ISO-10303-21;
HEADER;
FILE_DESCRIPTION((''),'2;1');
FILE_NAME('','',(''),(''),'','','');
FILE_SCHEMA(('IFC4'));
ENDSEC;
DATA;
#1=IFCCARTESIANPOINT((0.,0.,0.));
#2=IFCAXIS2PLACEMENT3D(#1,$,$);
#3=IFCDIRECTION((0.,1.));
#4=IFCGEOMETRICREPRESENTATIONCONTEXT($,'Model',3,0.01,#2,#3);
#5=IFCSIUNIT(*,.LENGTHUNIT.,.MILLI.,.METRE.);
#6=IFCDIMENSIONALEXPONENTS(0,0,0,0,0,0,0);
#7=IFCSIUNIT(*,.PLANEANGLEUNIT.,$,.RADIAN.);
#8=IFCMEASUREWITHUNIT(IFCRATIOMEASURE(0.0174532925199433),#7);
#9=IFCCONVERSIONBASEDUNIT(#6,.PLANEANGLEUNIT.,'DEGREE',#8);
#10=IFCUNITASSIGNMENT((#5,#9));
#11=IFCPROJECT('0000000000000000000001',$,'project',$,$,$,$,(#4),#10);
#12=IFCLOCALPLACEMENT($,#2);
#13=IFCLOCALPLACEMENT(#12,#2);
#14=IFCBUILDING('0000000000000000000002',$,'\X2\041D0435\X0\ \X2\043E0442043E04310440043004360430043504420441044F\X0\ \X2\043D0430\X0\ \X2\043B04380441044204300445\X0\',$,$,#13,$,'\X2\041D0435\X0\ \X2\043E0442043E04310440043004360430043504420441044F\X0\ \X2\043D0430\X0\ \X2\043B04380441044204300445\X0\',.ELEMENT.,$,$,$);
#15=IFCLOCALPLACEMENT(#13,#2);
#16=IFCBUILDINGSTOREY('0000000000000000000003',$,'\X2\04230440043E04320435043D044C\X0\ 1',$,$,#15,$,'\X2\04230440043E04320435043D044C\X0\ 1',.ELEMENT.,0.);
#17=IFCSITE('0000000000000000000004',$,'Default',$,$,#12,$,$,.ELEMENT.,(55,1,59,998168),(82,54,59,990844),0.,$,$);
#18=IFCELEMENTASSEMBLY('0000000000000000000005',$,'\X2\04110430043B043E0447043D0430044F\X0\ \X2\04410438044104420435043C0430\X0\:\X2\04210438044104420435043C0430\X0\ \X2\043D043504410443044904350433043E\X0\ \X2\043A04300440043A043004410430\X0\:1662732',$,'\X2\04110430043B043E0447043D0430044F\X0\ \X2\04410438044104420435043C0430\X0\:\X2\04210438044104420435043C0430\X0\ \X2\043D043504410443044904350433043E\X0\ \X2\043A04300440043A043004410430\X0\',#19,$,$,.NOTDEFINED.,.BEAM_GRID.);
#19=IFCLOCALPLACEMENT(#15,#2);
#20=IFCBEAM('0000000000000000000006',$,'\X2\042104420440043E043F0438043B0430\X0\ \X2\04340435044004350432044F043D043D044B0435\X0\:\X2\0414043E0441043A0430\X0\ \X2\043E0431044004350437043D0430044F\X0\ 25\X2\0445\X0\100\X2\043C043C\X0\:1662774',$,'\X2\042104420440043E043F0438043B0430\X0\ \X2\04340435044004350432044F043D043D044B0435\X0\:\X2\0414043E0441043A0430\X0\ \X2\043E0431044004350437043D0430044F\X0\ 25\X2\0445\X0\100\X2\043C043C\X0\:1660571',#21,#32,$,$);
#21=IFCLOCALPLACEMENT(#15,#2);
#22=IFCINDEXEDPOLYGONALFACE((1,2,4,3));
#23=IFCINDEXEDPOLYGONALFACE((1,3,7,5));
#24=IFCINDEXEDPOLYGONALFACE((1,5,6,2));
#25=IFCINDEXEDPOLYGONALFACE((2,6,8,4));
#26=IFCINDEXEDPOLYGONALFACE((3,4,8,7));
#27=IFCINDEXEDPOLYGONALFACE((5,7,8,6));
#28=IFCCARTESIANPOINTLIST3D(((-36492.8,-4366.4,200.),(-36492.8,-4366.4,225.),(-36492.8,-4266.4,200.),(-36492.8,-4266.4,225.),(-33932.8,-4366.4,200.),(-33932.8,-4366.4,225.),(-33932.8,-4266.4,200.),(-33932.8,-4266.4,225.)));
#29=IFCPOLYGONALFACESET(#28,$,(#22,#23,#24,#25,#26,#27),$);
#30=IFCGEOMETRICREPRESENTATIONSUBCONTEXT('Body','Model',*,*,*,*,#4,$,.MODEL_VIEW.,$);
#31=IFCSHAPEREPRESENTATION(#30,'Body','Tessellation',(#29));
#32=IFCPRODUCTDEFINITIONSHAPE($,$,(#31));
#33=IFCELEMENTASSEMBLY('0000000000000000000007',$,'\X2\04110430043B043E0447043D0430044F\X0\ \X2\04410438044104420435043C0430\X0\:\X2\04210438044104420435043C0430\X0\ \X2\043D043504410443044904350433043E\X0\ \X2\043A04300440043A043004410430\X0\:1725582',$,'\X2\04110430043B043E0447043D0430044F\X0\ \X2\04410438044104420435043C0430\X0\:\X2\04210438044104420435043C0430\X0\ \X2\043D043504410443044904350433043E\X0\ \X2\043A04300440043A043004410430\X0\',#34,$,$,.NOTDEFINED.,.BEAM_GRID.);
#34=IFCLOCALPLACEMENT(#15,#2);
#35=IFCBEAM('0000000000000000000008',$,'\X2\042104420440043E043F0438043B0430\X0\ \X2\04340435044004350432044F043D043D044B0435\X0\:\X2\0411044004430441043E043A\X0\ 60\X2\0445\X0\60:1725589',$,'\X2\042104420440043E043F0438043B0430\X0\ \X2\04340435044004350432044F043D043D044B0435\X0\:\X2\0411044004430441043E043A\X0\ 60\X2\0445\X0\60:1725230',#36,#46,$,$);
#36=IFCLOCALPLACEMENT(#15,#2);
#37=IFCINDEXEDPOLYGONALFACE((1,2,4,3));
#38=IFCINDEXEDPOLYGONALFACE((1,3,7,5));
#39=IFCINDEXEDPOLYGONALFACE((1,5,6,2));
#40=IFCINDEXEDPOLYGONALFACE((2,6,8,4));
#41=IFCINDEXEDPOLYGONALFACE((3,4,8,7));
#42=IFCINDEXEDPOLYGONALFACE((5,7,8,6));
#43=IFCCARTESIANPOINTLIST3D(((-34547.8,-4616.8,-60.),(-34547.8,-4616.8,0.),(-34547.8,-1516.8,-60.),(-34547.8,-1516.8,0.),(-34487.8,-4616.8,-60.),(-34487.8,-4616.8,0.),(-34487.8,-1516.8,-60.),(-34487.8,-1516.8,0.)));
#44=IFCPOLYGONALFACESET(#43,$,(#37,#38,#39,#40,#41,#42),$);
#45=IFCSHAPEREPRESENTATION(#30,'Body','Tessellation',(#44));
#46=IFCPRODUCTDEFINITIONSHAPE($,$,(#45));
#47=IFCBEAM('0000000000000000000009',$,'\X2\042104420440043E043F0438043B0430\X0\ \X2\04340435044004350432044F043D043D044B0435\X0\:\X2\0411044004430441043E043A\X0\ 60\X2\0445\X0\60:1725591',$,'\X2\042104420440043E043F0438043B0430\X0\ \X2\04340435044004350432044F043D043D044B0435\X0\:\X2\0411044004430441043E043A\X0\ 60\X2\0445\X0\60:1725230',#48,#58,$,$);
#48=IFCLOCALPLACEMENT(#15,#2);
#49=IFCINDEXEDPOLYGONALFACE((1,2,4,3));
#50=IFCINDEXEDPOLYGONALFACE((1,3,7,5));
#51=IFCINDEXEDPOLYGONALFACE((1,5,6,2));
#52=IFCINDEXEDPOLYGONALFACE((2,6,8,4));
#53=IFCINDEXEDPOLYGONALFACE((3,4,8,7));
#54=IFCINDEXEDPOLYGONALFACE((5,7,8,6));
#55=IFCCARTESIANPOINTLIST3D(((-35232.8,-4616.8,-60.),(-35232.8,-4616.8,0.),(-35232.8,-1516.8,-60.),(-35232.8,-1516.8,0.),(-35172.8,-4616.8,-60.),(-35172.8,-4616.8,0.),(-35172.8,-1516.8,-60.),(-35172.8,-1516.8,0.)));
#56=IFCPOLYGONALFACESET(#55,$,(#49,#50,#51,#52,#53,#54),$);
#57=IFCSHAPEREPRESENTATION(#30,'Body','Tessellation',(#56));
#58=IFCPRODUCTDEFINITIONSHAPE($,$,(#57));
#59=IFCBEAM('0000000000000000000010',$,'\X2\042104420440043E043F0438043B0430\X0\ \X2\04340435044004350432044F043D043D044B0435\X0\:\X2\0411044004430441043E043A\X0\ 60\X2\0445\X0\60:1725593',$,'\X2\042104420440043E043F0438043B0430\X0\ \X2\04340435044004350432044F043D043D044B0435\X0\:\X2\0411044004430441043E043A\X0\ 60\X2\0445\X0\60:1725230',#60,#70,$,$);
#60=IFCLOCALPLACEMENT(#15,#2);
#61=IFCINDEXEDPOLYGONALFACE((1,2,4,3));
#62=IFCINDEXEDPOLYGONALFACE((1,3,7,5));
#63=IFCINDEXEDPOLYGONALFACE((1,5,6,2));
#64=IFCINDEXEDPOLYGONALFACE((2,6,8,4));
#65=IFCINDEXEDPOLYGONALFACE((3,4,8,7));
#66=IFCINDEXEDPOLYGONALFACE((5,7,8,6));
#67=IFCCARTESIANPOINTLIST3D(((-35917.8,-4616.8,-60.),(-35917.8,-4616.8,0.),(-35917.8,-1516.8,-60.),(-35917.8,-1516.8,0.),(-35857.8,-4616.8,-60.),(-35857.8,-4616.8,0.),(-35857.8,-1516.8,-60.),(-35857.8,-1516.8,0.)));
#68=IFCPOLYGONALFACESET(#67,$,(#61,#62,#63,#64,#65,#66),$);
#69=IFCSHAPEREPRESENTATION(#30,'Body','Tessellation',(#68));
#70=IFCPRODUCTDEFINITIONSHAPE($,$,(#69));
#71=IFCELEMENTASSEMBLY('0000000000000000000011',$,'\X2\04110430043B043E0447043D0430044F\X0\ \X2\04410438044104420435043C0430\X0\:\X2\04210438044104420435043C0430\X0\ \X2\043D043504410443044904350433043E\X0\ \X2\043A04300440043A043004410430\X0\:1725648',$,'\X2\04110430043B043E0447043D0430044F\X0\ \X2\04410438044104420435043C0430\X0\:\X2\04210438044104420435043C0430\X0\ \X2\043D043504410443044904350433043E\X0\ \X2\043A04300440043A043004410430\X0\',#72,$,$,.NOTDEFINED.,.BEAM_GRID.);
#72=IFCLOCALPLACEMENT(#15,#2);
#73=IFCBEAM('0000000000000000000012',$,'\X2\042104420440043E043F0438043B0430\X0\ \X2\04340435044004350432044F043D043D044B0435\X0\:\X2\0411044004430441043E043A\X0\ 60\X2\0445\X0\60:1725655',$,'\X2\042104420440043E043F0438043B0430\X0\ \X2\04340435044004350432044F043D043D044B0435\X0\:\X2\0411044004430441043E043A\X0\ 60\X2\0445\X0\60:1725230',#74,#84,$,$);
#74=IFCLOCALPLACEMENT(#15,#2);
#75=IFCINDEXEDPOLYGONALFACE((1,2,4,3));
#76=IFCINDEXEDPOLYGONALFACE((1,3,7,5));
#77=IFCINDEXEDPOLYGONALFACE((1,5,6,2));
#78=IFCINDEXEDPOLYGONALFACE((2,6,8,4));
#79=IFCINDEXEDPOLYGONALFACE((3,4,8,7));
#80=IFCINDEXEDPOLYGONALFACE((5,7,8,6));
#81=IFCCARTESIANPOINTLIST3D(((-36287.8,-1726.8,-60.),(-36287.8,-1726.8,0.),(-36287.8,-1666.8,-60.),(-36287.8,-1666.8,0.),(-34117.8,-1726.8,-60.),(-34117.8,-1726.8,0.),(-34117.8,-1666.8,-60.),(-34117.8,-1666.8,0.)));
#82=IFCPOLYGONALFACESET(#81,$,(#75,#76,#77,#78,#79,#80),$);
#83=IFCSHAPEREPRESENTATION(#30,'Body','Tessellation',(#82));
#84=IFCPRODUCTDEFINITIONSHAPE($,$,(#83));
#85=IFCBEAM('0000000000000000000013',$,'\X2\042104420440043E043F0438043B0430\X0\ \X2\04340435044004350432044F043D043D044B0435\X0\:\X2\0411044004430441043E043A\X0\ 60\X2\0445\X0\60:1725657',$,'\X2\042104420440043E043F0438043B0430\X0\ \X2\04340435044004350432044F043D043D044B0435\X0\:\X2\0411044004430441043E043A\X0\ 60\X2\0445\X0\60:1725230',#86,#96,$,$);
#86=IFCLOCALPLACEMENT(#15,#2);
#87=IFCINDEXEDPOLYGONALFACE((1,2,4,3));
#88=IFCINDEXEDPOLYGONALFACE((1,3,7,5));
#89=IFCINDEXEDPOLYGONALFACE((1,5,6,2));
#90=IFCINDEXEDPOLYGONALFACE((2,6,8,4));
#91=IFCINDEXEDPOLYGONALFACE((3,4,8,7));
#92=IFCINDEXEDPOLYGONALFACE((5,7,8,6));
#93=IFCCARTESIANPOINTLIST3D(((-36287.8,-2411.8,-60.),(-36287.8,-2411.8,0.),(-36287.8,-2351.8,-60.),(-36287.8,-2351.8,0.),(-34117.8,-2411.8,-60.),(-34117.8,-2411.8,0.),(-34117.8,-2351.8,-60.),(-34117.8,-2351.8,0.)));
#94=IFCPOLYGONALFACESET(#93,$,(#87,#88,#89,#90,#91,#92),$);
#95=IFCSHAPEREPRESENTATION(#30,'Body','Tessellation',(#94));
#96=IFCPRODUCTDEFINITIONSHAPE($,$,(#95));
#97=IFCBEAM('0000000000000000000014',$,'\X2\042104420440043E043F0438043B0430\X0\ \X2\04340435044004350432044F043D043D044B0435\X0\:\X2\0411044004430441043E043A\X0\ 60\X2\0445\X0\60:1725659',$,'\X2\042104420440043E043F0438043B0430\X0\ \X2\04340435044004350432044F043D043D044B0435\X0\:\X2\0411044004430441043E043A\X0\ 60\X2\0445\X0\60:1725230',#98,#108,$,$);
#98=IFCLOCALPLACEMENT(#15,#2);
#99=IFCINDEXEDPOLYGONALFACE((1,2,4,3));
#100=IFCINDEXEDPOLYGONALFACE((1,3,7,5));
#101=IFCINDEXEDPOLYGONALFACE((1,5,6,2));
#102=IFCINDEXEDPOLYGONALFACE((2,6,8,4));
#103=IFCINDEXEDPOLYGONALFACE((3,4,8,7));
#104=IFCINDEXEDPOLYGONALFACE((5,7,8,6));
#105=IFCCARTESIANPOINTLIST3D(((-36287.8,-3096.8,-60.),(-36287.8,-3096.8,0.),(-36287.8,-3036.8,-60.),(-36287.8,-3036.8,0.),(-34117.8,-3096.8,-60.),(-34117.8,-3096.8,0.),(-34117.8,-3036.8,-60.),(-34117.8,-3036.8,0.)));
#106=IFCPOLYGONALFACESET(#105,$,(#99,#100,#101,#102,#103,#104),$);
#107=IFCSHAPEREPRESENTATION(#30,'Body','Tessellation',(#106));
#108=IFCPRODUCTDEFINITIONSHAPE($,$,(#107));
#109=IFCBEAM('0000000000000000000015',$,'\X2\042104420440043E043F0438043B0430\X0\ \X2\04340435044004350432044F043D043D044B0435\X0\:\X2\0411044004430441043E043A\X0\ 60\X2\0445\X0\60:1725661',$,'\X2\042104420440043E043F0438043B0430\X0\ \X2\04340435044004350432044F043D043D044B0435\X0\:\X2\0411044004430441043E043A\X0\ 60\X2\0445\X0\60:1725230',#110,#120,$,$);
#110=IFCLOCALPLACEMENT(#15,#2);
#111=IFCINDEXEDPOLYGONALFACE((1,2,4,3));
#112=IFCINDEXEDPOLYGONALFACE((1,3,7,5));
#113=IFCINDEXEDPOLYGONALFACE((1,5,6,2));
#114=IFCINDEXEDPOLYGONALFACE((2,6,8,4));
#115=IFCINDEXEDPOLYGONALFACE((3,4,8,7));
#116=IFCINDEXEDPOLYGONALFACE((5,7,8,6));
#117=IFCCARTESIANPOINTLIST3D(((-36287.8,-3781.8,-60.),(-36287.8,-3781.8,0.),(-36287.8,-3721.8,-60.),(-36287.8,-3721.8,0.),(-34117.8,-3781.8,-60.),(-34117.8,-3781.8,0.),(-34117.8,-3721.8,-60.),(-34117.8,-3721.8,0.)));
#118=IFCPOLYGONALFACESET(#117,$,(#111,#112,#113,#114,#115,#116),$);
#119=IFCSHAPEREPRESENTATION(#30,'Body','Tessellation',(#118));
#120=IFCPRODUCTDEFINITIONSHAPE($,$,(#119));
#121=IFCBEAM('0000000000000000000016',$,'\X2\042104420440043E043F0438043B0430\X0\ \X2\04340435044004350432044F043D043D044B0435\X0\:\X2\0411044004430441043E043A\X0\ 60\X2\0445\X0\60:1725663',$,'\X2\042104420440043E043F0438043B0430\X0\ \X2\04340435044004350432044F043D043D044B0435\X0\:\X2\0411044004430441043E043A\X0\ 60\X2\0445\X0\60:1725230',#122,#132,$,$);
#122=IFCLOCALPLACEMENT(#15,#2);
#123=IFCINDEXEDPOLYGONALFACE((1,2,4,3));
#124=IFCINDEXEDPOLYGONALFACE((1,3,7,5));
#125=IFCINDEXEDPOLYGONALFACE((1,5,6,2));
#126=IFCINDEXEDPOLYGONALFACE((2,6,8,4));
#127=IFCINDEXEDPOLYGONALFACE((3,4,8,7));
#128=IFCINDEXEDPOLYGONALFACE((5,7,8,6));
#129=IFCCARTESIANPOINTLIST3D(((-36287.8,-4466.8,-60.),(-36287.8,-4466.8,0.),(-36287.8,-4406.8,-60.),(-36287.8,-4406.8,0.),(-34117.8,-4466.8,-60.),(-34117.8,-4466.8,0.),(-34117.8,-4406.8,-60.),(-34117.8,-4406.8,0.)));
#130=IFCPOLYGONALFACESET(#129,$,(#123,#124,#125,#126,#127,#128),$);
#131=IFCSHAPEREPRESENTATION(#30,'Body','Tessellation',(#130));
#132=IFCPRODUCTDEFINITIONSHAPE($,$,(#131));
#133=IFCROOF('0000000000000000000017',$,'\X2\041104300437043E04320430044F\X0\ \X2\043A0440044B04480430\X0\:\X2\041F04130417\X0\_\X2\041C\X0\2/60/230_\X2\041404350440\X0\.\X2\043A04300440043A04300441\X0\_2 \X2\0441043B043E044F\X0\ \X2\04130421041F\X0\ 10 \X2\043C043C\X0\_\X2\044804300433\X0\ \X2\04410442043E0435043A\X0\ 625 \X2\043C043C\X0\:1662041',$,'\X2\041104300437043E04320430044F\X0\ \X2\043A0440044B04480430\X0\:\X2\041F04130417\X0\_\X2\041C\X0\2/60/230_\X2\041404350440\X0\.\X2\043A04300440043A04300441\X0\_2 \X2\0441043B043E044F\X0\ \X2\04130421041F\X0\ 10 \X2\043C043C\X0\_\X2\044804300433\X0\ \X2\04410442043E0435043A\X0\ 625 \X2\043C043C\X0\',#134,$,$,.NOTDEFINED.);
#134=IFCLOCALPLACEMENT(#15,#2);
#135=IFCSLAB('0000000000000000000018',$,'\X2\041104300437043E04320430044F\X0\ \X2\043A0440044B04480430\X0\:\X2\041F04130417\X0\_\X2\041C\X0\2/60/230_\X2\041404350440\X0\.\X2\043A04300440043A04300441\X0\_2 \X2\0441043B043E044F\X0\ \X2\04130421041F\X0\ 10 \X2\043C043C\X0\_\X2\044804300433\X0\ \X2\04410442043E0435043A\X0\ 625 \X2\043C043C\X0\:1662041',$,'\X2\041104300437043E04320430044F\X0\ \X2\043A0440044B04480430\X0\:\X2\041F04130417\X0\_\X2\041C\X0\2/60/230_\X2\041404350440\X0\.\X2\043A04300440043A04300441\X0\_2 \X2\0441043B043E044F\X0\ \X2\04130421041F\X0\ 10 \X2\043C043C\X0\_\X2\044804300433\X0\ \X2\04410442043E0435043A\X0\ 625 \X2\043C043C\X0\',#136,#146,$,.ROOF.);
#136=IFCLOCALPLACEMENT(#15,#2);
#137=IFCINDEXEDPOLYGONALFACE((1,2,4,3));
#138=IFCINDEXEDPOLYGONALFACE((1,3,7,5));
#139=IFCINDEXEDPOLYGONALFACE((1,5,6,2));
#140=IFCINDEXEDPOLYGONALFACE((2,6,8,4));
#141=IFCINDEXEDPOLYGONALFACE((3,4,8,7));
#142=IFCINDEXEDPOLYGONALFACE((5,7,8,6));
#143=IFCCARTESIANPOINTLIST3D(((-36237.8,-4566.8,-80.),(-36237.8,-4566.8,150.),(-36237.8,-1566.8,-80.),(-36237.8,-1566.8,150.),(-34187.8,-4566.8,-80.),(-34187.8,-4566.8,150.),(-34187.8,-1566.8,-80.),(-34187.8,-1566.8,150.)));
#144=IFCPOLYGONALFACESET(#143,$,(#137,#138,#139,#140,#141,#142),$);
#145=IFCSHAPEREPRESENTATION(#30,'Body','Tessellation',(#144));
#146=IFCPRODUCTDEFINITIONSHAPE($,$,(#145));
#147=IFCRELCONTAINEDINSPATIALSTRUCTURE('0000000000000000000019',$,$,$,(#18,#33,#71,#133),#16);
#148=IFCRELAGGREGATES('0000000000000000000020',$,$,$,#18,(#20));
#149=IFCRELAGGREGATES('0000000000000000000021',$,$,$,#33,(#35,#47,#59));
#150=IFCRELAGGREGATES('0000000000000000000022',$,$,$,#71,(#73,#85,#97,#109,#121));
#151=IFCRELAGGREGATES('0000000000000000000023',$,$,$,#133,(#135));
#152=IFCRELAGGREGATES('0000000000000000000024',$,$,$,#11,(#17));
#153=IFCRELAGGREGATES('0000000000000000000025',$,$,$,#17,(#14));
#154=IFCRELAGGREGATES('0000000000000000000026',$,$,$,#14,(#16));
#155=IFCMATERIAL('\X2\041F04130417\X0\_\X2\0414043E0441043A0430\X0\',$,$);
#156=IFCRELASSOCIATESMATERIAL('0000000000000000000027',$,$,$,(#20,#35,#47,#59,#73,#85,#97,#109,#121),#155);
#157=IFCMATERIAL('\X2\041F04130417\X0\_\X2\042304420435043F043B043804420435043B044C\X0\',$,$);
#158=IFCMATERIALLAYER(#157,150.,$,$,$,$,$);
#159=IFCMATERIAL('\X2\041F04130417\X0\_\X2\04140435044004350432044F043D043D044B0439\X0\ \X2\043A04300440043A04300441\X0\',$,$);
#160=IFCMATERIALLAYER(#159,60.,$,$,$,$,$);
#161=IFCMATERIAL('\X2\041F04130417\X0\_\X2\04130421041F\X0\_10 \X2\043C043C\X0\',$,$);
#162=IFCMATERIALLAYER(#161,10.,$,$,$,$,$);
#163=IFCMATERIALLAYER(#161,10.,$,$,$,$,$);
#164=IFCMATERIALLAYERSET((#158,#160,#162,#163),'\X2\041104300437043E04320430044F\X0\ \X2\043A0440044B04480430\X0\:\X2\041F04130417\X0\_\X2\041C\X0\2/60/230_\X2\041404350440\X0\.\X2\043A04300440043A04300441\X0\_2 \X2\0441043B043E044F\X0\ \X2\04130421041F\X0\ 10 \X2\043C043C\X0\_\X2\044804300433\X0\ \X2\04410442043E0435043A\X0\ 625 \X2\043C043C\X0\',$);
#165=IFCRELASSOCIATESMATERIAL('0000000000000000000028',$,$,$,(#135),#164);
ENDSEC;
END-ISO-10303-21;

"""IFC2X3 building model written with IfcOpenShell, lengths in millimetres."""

from ifc_helpers import new_model, entity, si_unit, converted_unit, direction, frame, frame_2d, origin, origin_2d_with_axis, place, context, subcontext, project, spatial, rectangle, extrude, material, layer, layer_set, element, aggregate, save


model = new_model("IFC2X3")

# Units and contexts
model_context = context("Model", 3, precision=0.01, world=origin(), true_north=direction((0.0, 1.0)))
body_context = subcontext(model_context, "Body", "Model", "MODEL_VIEW")
ifc_project = project(units=[si_unit("LENGTHUNIT", "METRE", prefix="MILLI"), converted_unit("PLANEANGLEUNIT", "DEGREE", entity("IfcRatioMeasure", 0.0174532925199433), si_unit("PLANEANGLEUNIT", "RADIAN"), dimensions=[0, 0, 0, 0, 0, 0, 0])], contexts=[model_context])

# Site, building, storey
site_placement = place(None, origin())
site = spatial("IfcSite", under=ifc_project, at=site_placement, Name="Default", CompositionType="ELEMENT", RefLatitude=(55, 1, 59, 998168), RefLongitude=(82, 54, 59, 990844), RefElevation=0.0)
building_placement = place(site_placement, origin())
building = spatial("IfcBuilding", under=site, at=building_placement, Name="Не отображается на листах", LongName="Не отображается на листах", CompositionType="ELEMENT")
storey_placement = place(building_placement, frame((0.0, 0.0, 0.0)))
storey = spatial("IfcBuildingStorey", under=building, at=storey_placement, Name="Уровень 1", LongName="Уровень 1", CompositionType="ELEMENT", Elevation=0.0)

# Element assemblies, beams
ifc_material_1 = material(Name="ПГЗ_Доска")
assembly_1_placement = place(storey_placement, origin())
assembly_1 = element("IfcElementAssembly", 1, at=assembly_1_placement, inside=storey, Name="Балочная система:Система несущего каркаса:1662732", ObjectType="Балочная система:Система несущего каркаса", AssemblyPlace="NOTDEFINED", PredefinedType="BEAM_GRID")
beam_1_placement = place(assembly_1_placement, frame((-36492.8, -4316.4, 0.0)))
beam_1 = element("IfcBeam", 2, at=beam_1_placement, material=ifc_material_1, Name="Стропила деревянные:Доска обрезная 25х100мм:1662774", ObjectType="Стропила деревянные:Доска обрезная 25х100мм:1660571", context=body_context, shape_type="SweptSolid", body=[
    extrude(rectangle(XDim=25.0, YDim=100.0, at=origin_2d_with_axis()), frame((0.0, 0.0, 212.5), z_axis=(1.0, 0.0, 0.0), x_axis=(0.0, 0.0, -1.0)), (0.0, 0.0, 1.0), 2560.0),
])
aggregate(assembly_1, [beam_1])
assembly_2_placement = place(storey_placement, origin())
assembly_2 = element("IfcElementAssembly", 3, at=assembly_2_placement, inside=storey, Name="Балочная система:Система несущего каркаса:1725582", ObjectType="Балочная система:Система несущего каркаса", AssemblyPlace="NOTDEFINED", PredefinedType="BEAM_GRID")
beam_2_placement = place(assembly_2_placement, frame((-34517.8, -1516.8, 0.0), z_axis=(0.0, 0.0, 1.0), x_axis=(0.0, -1.0, 0.0)))
beam_2 = element("IfcBeam", 4, at=beam_2_placement, material=ifc_material_1, Name="Стропила деревянные:Брусок 60х60:1725589", ObjectType="Стропила деревянные:Брусок 60х60:1725230", context=body_context, shape_type="SweptSolid", body=[
    extrude(rectangle(XDim=60.0, YDim=60.0, at=frame_2d((0.0, 0.0), x_axis=(1.0, 0.0))), frame((0.0, 0.0, -30.0), z_axis=(1.0, 0.0, 0.0), x_axis=(0.0, 0.0, -1.0)), (0.0, 0.0, 1.0), 3100.0),
])
beam_3_placement = place(assembly_2_placement, frame((-35202.8, -1516.8, 0.0), z_axis=(0.0, 0.0, 1.0), x_axis=(0.0, -1.0, 0.0)))
beam_3 = element("IfcBeam", 5, at=beam_3_placement, material=ifc_material_1, Name="Стропила деревянные:Брусок 60х60:1725591", ObjectType="Стропила деревянные:Брусок 60х60:1725230", context=body_context, shape_type="SweptSolid", body=[
    extrude(rectangle(XDim=60.0, YDim=60.0, at=frame_2d((0.0, 0.0), x_axis=(1.0, 0.0))), frame((0.0, 0.0, -30.0), z_axis=(1.0, 0.0, 0.0), x_axis=(0.0, 0.0, -1.0)), (0.0, 0.0, 1.0), 3100.0),
])
beam_4_placement = place(assembly_2_placement, frame((-35887.8, -1516.8, 0.0), z_axis=(0.0, 0.0, 1.0), x_axis=(0.0, -1.0, 0.0)))
beam_4 = element("IfcBeam", 6, at=beam_4_placement, material=ifc_material_1, Name="Стропила деревянные:Брусок 60х60:1725593", ObjectType="Стропила деревянные:Брусок 60х60:1725230", context=body_context, shape_type="SweptSolid", body=[
    extrude(rectangle(XDim=60.0, YDim=60.0, at=frame_2d((0.0, 0.0), x_axis=(1.0, 0.0))), frame((0.0, 0.0, -30.0), z_axis=(1.0, 0.0, 0.0), x_axis=(0.0, 0.0, -1.0)), (0.0, 0.0, 1.0), 3100.0),
])
aggregate(assembly_2, [beam_2, beam_3, beam_4])
assembly_3_placement = place(storey_placement, origin())
assembly_3 = element("IfcElementAssembly", 7, at=assembly_3_placement, inside=storey, Name="Балочная система:Система несущего каркаса:1725648", ObjectType="Балочная система:Система несущего каркаса", AssemblyPlace="NOTDEFINED", PredefinedType="BEAM_GRID")
beam_5_placement = place(assembly_3_placement, frame((-36287.8, -1696.8, 0.0)))
beam_5 = element("IfcBeam", 8, at=beam_5_placement, material=ifc_material_1, Name="Стропила деревянные:Брусок 60х60:1725655", ObjectType="Стропила деревянные:Брусок 60х60:1725230", context=body_context, shape_type="SweptSolid", body=[
    extrude(rectangle(XDim=60.0, YDim=60.0, at=frame_2d((0.0, 0.0), x_axis=(1.0, 0.0))), frame((0.0, 0.0, -30.0), z_axis=(1.0, 0.0, 0.0), x_axis=(0.0, 0.0, -1.0)), (0.0, 0.0, 1.0), 2170.0),
])
beam_6_placement = place(assembly_3_placement, frame((-36287.8, -2381.8, 0.0)))
beam_6 = element("IfcBeam", 9, at=beam_6_placement, material=ifc_material_1, Name="Стропила деревянные:Брусок 60х60:1725657", ObjectType="Стропила деревянные:Брусок 60х60:1725230", context=body_context, shape_type="SweptSolid", body=[
    extrude(rectangle(XDim=60.0, YDim=60.0, at=frame_2d((0.0, 0.0), x_axis=(1.0, 0.0))), frame((0.0, 0.0, -30.0), z_axis=(1.0, 0.0, 0.0), x_axis=(0.0, 0.0, -1.0)), (0.0, 0.0, 1.0), 2170.0),
])
beam_7_placement = place(assembly_3_placement, frame((-36287.8, -3066.8, 0.0)))
beam_7 = element("IfcBeam", 10, at=beam_7_placement, material=ifc_material_1, Name="Стропила деревянные:Брусок 60х60:1725659", ObjectType="Стропила деревянные:Брусок 60х60:1725230", context=body_context, shape_type="SweptSolid", body=[
    extrude(rectangle(XDim=60.0, YDim=60.0, at=frame_2d((0.0, 0.0), x_axis=(1.0, 0.0))), frame((0.0, 0.0, -30.0), z_axis=(1.0, 0.0, 0.0), x_axis=(0.0, 0.0, -1.0)), (0.0, 0.0, 1.0), 2170.0),
])
beam_8_placement = place(assembly_3_placement, frame((-36287.8, -3751.8, 0.0)))
beam_8 = element("IfcBeam", 11, at=beam_8_placement, material=ifc_material_1, Name="Стропила деревянные:Брусок 60х60:1725661", ObjectType="Стропила деревянные:Брусок 60х60:1725230", context=body_context, shape_type="SweptSolid", body=[
    extrude(rectangle(XDim=60.0, YDim=60.0, at=frame_2d((0.0, 0.0), x_axis=(1.0, 0.0))), frame((0.0, 0.0, -30.0), z_axis=(1.0, 0.0, 0.0), x_axis=(0.0, 0.0, -1.0)), (0.0, 0.0, 1.0), 2170.0),
])
beam_9_placement = place(assembly_3_placement, frame((-36287.8, -4436.8, 0.0)))
beam_9 = element("IfcBeam", 12, at=beam_9_placement, material=ifc_material_1, Name="Стропила деревянные:Брусок 60х60:1725663", ObjectType="Стропила деревянные:Брусок 60х60:1725230", context=body_context, shape_type="SweptSolid", body=[
    extrude(rectangle(XDim=60.0, YDim=60.0, at=frame_2d((0.0, 0.0), x_axis=(1.0, 0.0))), frame((0.0, 0.0, -30.0), z_axis=(1.0, 0.0, 0.0), x_axis=(0.0, 0.0, -1.0)), (0.0, 0.0, 1.0), 2170.0),
])
aggregate(assembly_3, [beam_5, beam_6, beam_7, beam_8, beam_9])

# Roof, slab
roof_placement = place(storey_placement, frame((-36237.8, -4566.8, -80.0)))
roof = element("IfcRoof", 13, at=roof_placement, inside=storey, Name="Базовая крыша:ПГЗ_М2/60/230_Дер.каркас_2 слоя ГСП 10 мм_шаг стоек 625 мм:1662041", ObjectType="Базовая крыша:ПГЗ_М2/60/230_Дер.каркас_2 слоя ГСП 10 мм_шаг стоек 625 мм", ShapeType="NOTDEFINED")
ifc_material_2 = material(Name="ПГЗ_Утеплитель")
ifc_layer_1 = layer(ifc_material_2, 150.0)
ifc_material_3 = material(Name="ПГЗ_Деревянный каркас")
ifc_layer_2 = layer(ifc_material_3, 60.0)
ifc_material_4 = material(Name="ПГЗ_ГСП_10 мм")
ifc_layer_3 = layer(ifc_material_4, 10.0)
ifc_layer_4 = layer(ifc_material_4, 10.0)
ifc_layer_set = layer_set([ifc_layer_1, ifc_layer_2, ifc_layer_3, ifc_layer_4], Name="Базовая крыша:ПГЗ_М2/60/230_Дер.каркас_2 слоя ГСП 10 мм_шаг стоек 625 мм")
slab_placement = place(roof_placement, origin())
slab = element("IfcSlab", 14, at=slab_placement, material=ifc_layer_set, Name="Базовая крыша:ПГЗ_М2/60/230_Дер.каркас_2 слоя ГСП 10 мм_шаг стоек 625 мм:1662041", ObjectType="Базовая крыша:ПГЗ_М2/60/230_Дер.каркас_2 слоя ГСП 10 мм_шаг стоек 625 мм", PredefinedType="ROOF", context=body_context, shape_type="SweptSolid", body=[
    extrude(rectangle(XDim=2050.0, YDim=3000.0, at=frame_2d((0.0, 0.0), x_axis=(1.0, 0.0))), frame((1025.0, 1500.0, 0.0)), (0.0, 0.0, 1.0), 230.0),
])
aggregate(roof, [slab])

save(model, "model.ifc")
